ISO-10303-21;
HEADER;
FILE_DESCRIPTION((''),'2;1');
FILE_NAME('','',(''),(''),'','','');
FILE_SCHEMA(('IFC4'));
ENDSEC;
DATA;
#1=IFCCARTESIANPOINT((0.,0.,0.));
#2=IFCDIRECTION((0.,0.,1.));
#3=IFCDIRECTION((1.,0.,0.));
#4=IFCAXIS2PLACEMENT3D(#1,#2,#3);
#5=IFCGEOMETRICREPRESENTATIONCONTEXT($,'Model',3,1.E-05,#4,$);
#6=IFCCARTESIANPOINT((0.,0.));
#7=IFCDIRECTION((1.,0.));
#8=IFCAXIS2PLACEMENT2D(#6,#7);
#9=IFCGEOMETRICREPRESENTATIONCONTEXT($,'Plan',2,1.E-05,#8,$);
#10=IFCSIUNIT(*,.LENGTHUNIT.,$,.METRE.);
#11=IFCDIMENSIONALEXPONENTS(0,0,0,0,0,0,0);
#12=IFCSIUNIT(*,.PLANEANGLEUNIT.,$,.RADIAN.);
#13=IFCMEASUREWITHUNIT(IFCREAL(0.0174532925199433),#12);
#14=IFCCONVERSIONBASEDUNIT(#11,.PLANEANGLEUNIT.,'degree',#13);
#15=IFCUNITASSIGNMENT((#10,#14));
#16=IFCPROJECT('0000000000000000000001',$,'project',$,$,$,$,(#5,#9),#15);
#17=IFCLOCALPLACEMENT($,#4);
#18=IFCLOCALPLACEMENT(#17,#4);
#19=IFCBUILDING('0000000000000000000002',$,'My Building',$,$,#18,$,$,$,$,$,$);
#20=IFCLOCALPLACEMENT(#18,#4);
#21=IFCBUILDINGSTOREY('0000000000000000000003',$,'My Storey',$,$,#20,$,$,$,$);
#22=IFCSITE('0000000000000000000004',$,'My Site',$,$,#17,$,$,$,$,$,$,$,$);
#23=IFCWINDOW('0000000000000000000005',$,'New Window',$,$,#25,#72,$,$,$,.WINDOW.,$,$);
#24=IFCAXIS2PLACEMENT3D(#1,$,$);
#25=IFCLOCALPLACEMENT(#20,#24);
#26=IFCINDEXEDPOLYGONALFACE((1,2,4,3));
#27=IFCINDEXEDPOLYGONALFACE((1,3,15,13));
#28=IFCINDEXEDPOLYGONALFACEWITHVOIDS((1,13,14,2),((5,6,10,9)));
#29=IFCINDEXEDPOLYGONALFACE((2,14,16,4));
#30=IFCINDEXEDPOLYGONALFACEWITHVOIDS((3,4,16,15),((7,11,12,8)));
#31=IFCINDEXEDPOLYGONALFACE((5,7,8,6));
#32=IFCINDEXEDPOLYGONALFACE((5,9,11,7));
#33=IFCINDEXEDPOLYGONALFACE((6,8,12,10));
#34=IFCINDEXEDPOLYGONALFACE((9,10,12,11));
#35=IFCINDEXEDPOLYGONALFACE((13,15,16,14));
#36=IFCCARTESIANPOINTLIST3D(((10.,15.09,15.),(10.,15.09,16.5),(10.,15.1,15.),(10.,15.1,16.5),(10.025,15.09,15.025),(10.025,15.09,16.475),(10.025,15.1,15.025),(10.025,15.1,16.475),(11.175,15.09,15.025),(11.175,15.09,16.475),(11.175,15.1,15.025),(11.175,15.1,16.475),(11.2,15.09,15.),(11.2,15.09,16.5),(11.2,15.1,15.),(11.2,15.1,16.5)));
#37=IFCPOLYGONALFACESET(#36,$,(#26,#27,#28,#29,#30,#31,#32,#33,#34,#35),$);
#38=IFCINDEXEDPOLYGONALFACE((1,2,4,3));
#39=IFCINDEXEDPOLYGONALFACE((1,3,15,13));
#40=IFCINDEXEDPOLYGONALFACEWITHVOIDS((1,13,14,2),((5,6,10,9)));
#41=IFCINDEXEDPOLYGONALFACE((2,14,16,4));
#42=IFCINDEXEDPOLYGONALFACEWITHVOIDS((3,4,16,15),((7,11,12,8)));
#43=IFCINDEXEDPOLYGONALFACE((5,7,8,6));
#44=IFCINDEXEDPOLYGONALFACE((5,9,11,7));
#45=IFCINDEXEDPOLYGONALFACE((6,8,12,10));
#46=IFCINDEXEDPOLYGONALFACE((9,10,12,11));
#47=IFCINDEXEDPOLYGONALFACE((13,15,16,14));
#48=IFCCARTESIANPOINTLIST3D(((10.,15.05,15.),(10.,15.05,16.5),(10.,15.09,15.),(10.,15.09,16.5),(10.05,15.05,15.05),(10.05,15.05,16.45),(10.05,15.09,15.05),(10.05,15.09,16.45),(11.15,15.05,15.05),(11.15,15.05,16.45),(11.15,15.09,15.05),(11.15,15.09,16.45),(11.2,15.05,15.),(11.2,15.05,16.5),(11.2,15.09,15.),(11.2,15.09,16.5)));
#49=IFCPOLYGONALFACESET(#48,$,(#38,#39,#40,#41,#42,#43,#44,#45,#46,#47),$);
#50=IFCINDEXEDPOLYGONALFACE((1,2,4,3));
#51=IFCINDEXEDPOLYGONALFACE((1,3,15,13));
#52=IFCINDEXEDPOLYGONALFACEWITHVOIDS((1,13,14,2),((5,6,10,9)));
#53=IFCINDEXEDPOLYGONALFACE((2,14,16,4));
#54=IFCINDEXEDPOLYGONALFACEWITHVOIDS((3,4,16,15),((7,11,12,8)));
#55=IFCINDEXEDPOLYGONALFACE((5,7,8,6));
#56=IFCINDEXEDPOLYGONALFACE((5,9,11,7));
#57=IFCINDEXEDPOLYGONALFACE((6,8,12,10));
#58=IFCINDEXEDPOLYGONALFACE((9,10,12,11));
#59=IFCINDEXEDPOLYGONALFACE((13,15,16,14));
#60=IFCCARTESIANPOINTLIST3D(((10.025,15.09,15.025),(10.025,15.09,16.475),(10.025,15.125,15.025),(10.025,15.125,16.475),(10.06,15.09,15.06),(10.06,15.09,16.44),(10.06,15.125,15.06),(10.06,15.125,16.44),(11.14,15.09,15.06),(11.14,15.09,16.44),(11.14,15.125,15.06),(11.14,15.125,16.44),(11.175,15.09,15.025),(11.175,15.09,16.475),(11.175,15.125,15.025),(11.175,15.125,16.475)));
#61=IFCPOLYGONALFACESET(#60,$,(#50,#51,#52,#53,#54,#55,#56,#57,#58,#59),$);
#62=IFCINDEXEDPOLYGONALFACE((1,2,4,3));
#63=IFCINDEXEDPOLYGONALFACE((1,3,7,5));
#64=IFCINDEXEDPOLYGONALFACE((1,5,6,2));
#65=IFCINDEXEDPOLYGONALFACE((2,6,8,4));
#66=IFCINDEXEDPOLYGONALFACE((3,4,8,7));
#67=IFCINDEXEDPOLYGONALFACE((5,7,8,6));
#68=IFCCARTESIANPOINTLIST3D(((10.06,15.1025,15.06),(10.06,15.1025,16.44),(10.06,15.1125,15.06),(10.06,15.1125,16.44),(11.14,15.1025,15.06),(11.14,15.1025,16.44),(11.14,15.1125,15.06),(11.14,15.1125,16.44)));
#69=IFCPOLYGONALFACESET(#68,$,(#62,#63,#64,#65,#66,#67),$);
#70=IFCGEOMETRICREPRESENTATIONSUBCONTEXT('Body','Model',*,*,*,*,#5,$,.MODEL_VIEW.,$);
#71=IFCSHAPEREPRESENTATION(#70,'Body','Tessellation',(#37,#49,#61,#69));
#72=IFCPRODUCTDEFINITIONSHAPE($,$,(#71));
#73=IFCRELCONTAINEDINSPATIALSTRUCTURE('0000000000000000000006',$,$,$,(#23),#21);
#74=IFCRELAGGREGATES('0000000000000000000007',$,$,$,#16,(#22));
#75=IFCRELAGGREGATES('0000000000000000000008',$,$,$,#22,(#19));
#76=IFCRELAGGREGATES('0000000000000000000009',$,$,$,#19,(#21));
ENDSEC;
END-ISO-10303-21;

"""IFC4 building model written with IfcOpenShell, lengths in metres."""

from ifc_helpers import new_model, entity, si_unit, converted_unit, frame, origin_with_axes, origin_2d_with_axis, place, context, subcontext, project, spatial, line, indexed_curve, outline, extrude, element, save


model = new_model("IFC4")

# Units and contexts
model_context = context("Model", 3, precision=1e-05, world=origin_with_axes())
plan_context = context("Plan", 2, precision=1e-05, world=origin_2d_with_axis())
body_context = subcontext(model_context, "Body", "Model", "MODEL_VIEW")
ifc_project = project(units=[si_unit("LENGTHUNIT", "METRE"), converted_unit("PLANEANGLEUNIT", "degree", entity("IfcReal", 0.0174532925199433), si_unit("PLANEANGLEUNIT", "RADIAN"), dimensions=[0, 0, 0, 0, 0, 0, 0])], contexts=[model_context, plan_context])

# Site, building, storey
site_placement = place(None, origin_with_axes())
site = spatial("IfcSite", under=ifc_project, at=site_placement, Name="My Site")
building_placement = place(site_placement, origin_with_axes())
building = spatial("IfcBuilding", under=site, at=building_placement, Name="My Building")
storey_placement = place(building_placement, origin_with_axes())
storey = spatial("IfcBuildingStorey", under=building, at=storey_placement, Name="My Storey")

# Window
for number, where, z_axis, x_axis, name in (
    (1, (10.0, 15.0, 15.0), (0.0, 0.0, 1.0), (1.0, 0.0, 0.0), "New Window"),
):
    element("IfcWindow", number, at=place(storey_placement, frame(where, z_axis=z_axis, x_axis=x_axis)), inside=storey, Name=name, PredefinedType="WINDOW", context=body_context, shape_type="SweptSolid", body=[
        extrude(outline(indexed_curve([(0.0, 0.0), (1.2, 0.0), (1.2, 1.5), (0.0, 1.5)], segments=[line(1, 2, 3, 4, 1)]), holes=[indexed_curve([(0.025, 0.025), (1.175, 0.025), (1.175, 1.475), (0.025, 1.475)], segments=[line(1, 2, 3, 4, 1)])]), frame((0.0, 0.09, 0.0), z_axis=(0.0, -1.0, 0.0), x_axis=(1.0, 0.0, 0.0)), (0.0, 0.0, -1.0), 0.01),
        extrude(outline(indexed_curve([(0.0, 0.0), (1.2, 0.0), (1.2, 1.5), (0.0, 1.5)], segments=[line(1, 2, 3, 4, 1)]), holes=[indexed_curve([(0.05, 0.05), (1.15, 0.05), (1.15, 1.45), (0.05, 1.45)], segments=[line(1, 2, 3, 4, 1)])]), frame((0.0, 0.05, 0.0), z_axis=(0.0, -1.0, 0.0), x_axis=(1.0, 0.0, 0.0)), (0.0, 0.0, -1.0), 0.04),
        extrude(outline(indexed_curve([(0.0, 0.0), (1.15, 0.0), (1.15, 1.45), (0.0, 1.45)], segments=[line(1, 2, 3, 4, 1)]), holes=[indexed_curve([(0.035, 0.035), (1.115, 0.035), (1.115, 1.415), (0.035, 1.415)], segments=[line(1, 2, 3, 4, 1)])]), frame((0.025, 0.09, 0.025), z_axis=(0.0, -1.0, 0.0), x_axis=(1.0, 0.0, 0.0)), (0.0, 0.0, -1.0), 0.035),
        extrude(outline(indexed_curve([(0.035, 0.035), (1.115, 0.035), (1.115, 1.415), (0.035, 1.415)], segments=[line(1, 2, 3, 4, 1)])), frame((0.025, 0.1025, 0.025), z_axis=(0.0, -1.0, 0.0), x_axis=(1.0, 0.0, 0.0)), (0.0, 0.0, -1.0), 0.01),
    ])

save(model, "model.ifc")
